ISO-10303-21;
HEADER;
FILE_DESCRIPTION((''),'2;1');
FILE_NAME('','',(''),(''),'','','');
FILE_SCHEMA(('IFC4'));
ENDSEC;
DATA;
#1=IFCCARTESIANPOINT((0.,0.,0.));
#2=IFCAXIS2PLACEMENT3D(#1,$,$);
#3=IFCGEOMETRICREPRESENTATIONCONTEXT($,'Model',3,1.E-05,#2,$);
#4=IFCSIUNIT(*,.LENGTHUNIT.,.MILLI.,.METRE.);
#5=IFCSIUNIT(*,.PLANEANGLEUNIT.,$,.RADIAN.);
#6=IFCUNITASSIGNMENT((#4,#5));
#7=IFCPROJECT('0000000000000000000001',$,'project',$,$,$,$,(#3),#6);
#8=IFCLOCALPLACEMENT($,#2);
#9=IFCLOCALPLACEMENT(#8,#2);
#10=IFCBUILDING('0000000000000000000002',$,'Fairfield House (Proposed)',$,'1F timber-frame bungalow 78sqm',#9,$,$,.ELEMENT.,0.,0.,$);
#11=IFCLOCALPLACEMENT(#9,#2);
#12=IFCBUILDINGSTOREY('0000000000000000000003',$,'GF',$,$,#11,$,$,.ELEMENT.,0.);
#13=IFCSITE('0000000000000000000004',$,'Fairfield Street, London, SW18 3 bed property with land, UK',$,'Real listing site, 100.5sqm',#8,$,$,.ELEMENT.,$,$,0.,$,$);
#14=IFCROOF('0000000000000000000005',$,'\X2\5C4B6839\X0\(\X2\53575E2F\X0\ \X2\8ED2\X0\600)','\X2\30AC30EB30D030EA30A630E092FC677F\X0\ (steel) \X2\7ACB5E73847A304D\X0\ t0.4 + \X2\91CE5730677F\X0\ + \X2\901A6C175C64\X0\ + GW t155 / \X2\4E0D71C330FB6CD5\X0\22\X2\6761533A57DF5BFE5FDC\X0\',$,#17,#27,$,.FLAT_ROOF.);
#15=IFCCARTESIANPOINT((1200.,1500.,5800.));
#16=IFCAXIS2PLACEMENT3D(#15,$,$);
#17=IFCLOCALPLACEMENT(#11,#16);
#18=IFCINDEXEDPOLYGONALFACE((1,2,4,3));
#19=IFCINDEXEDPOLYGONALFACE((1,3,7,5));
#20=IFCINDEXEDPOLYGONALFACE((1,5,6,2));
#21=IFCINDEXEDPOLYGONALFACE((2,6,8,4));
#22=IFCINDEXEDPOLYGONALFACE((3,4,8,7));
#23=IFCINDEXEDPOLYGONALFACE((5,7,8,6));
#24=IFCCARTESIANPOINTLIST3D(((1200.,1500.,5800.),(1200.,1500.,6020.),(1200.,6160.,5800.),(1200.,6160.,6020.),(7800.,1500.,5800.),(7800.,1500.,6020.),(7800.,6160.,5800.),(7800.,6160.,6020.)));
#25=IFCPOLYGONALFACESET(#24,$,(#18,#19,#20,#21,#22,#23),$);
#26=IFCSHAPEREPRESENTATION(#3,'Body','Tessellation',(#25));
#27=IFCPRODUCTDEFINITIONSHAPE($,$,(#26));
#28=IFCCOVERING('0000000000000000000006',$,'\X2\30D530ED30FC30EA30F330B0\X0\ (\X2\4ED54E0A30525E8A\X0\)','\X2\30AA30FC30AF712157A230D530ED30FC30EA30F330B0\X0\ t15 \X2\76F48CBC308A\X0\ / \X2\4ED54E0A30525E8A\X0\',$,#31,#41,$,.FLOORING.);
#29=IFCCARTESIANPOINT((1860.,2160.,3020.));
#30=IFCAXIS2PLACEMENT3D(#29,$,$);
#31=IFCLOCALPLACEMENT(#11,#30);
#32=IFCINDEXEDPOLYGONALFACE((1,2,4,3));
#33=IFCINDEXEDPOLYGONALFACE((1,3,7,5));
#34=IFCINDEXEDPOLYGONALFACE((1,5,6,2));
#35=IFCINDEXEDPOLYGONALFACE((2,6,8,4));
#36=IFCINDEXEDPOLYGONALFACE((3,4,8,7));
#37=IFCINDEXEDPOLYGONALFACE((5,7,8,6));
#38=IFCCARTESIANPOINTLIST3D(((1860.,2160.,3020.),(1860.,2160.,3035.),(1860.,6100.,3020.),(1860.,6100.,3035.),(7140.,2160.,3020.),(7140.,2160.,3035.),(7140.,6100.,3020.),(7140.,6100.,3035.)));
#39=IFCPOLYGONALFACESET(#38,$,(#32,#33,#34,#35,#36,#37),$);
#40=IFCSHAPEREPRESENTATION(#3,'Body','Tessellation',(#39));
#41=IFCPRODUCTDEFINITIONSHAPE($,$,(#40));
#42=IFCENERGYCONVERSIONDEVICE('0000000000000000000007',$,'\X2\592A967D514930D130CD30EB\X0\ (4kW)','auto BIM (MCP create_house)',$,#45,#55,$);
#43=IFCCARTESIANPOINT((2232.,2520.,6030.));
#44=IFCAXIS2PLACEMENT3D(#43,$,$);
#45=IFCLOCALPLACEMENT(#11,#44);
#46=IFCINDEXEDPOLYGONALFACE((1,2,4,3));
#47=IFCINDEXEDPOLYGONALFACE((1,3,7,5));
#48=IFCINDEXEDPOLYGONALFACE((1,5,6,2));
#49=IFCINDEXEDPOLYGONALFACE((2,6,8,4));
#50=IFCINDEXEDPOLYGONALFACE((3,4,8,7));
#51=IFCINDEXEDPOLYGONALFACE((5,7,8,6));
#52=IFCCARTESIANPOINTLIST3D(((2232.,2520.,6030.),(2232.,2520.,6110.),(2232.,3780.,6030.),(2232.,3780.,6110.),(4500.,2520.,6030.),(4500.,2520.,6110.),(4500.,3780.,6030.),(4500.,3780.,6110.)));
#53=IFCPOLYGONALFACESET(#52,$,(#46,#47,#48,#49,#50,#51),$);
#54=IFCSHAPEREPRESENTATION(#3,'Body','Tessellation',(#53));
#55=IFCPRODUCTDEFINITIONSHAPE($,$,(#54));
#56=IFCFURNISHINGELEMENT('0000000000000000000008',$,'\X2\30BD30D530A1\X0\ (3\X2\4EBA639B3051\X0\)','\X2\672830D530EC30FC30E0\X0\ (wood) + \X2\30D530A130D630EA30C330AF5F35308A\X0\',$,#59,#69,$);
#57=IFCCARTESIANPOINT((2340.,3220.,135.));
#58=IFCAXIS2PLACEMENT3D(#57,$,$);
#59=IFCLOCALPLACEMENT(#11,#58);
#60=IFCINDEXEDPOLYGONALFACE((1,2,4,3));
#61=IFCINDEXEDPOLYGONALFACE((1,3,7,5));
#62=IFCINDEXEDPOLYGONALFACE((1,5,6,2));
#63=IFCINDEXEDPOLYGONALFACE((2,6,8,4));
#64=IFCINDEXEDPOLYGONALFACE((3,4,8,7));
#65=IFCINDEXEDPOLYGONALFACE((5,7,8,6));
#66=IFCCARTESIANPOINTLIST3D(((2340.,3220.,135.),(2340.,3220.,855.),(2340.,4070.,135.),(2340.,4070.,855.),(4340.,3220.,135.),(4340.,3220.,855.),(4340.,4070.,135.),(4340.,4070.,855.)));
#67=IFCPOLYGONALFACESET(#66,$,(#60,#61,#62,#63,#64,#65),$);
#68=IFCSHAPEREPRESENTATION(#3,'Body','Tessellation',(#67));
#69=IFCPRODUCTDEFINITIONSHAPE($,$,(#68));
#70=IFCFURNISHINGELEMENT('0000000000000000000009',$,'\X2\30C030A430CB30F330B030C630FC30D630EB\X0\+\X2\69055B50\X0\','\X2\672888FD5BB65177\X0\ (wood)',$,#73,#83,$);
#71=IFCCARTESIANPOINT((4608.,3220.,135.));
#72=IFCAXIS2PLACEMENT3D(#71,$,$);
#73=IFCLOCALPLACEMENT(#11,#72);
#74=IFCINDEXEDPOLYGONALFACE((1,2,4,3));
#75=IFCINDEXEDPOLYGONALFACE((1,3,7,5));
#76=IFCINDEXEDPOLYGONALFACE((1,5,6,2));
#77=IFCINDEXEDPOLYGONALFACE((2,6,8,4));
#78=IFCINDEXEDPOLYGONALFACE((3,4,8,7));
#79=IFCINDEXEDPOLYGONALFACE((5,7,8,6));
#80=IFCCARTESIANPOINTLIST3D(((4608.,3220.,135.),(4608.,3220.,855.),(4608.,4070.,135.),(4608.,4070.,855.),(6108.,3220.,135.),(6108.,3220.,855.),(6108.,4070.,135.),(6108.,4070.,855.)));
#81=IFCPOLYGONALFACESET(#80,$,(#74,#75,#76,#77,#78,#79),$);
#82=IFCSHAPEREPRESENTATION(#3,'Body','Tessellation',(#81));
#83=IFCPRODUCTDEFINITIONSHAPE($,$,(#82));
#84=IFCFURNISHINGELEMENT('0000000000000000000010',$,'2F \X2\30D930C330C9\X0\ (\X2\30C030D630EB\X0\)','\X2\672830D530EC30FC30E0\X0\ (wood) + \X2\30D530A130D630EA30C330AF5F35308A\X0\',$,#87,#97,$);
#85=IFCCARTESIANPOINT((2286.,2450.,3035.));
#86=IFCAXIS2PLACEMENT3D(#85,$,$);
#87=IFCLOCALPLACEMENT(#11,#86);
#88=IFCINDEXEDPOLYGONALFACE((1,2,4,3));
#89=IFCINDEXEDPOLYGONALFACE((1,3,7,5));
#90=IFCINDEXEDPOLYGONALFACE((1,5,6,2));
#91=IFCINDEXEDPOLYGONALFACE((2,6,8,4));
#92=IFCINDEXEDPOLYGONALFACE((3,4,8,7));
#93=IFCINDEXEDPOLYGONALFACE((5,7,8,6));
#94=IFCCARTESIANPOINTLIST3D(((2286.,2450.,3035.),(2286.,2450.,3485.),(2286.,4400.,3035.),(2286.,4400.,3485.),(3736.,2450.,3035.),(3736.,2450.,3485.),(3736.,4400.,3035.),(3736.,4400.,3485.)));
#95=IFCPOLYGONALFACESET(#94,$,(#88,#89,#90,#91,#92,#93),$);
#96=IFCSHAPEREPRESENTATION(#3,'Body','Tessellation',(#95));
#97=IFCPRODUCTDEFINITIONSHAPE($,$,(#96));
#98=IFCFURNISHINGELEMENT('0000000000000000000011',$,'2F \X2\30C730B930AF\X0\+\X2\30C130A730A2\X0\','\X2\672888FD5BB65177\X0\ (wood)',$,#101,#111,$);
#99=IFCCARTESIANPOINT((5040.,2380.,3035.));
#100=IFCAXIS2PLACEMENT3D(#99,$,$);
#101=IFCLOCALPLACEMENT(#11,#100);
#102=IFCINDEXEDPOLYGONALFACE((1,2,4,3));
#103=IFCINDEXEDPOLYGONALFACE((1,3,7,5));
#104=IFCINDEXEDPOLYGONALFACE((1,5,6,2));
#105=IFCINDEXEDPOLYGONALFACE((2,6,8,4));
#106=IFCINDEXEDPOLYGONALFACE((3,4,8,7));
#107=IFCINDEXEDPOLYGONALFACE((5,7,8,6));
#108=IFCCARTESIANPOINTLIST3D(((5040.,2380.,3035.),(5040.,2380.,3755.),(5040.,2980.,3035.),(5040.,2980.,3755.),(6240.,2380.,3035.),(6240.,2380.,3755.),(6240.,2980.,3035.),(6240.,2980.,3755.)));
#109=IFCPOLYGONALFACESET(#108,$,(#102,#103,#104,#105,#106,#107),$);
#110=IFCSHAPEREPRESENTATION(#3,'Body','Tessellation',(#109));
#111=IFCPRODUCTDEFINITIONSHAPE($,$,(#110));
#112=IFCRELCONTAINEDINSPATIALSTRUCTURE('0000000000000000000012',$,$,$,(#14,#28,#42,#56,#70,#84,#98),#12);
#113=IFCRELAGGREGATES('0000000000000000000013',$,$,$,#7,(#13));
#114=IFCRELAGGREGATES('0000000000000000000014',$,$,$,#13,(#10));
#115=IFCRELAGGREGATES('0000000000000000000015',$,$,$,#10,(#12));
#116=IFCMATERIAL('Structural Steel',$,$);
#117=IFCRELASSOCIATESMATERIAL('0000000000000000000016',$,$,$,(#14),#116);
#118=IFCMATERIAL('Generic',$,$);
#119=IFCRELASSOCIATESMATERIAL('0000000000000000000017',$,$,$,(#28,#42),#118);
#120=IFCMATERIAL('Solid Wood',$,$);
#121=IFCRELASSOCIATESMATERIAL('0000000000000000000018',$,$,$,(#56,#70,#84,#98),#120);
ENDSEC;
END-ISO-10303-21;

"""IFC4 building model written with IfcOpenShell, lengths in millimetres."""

from ifc_helpers import new_model, si_unit, frame, frame_2d, origin, place, context, project, spatial, rectangle, extrude, material, element, save


model = new_model("IFC4")

# Units and contexts
model_context = context("Model", 3, precision=1e-05, world=origin())
ifc_project = project(units=[si_unit("LENGTHUNIT", "METRE", prefix="MILLI"), si_unit("PLANEANGLEUNIT", "RADIAN")], contexts=[model_context])

# Site, building, storey
site_placement = place(None, origin())
site = spatial("IfcSite", under=ifc_project, at=site_placement, Name="Fairfield Street, London, SW18 3 bed property with land, UK", ObjectType="Real listing site, 100.5sqm", CompositionType="ELEMENT", RefElevation=0.0)
building_placement = place(site_placement, origin())
building = spatial("IfcBuilding", under=site, at=building_placement, Name="Fairfield House (Proposed)", ObjectType="1F timber-frame bungalow 78sqm", CompositionType="ELEMENT", ElevationOfRefHeight=0.0, ElevationOfTerrain=0.0)
storey_placement = place(building_placement, origin())
storey = spatial("IfcBuildingStorey", under=building, at=storey_placement, Name="GF", CompositionType="ELEMENT", Elevation=0.0)

# Shared definitions
ifc_material_1 = material(Name="Solid Wood")

# Shared definitions
ifc_material_2 = material(Name="Generic")

# Roof
ifc_material_3 = material(Name="Structural Steel")
for number, where, name in (
    (1, (1200.0, 1500.0, 5800.0), "屋根(南帯 軒600)"),
):
    element("IfcRoof", number, at=place(storey_placement, frame(where)), inside=storey, material=ifc_material_3, Name=name, Description="ガルバリウム鋼板 (steel) 立平葺き t0.4 + 野地板 + 通気層 + GW t155 / 不燃・法22条区域対応", PredefinedType="FLAT_ROOF", context=model_context, shape_type="SweptSolid", body=[
        extrude(rectangle(XDim=6600.0, YDim=4660.0, at=frame_2d((3300.0, 2330.0))), frame((1200.0, 1500.0, 5800.0)), (0.0, 0.0, 1.0), 220.0),
    ])

# Covering
covering_placement = place(storey_placement, frame((1860.0, 2160.0, 3020.0)))
element("IfcCovering", 2, at=covering_placement, inside=storey, material=ifc_material_2, Name="フローリング (仕上げ床)", Description="オーク無垢フローリング t15 直貼り / 仕上げ床", PredefinedType="FLOORING", context=model_context, shape_type="SweptSolid", body=[
    extrude(rectangle(XDim=5280.0, YDim=3940.0, at=frame_2d((2640.0, 1970.0))), frame((1860.0, 2160.0, 3020.0)), (0.0, 0.0, 1.0), 15.0),
])

# Energy conversion device
energy_conversion_device_placement = place(storey_placement, frame((2232.0, 2520.0, 6030.0)))
element("IfcEnergyConversionDevice", 3, at=energy_conversion_device_placement, inside=storey, material=ifc_material_2, Name="太陽光パネル (4kW)", Description="auto BIM (MCP create_house)", context=model_context, shape_type="SweptSolid", body=[
    extrude(rectangle(XDim=2268.0, YDim=1260.0, at=frame_2d((1134.0, 630.0))), frame((2232.0, 2520.0, 6030.0)), (0.0, 0.0, 1.0), 80.0),
])

# Furnishing elements
furnishing_1_placement = place(storey_placement, frame((2340.0, 3220.0, 135.0)))
element("IfcFurnishingElement", 4, at=furnishing_1_placement, inside=storey, material=ifc_material_1, Name="ソファ (3人掛け)", Description="木フレーム (wood) + ファブリック張り", context=model_context, shape_type="SweptSolid", body=[
    extrude(rectangle(XDim=2000.0, YDim=850.0, at=frame_2d((1000.0, 425.0))), frame((2340.0, 3220.0, 135.0)), (0.0, 0.0, 1.0), 720.0),
])
furnishing_2_placement = place(storey_placement, frame((4608.0, 3220.0, 135.0)))
element("IfcFurnishingElement", 5, at=furnishing_2_placement, inside=storey, material=ifc_material_1, Name="ダイニングテーブル+椅子", Description="木製家具 (wood)", context=model_context, shape_type="SweptSolid", body=[
    extrude(rectangle(XDim=1500.0, YDim=850.0, at=frame_2d((750.0, 425.0))), frame((4608.0, 3220.0, 135.0)), (0.0, 0.0, 1.0), 720.0),
])
furnishing_3_placement = place(storey_placement, frame((2286.0, 2450.0, 3035.0)))
element("IfcFurnishingElement", 6, at=furnishing_3_placement, inside=storey, material=ifc_material_1, Name="2F ベッド (ダブル)", Description="木フレーム (wood) + ファブリック張り", context=model_context, shape_type="SweptSolid", body=[
    extrude(rectangle(XDim=1450.0, YDim=1950.0, at=frame_2d((725.0, 975.0))), frame((2286.0, 2450.0, 3035.0)), (0.0, 0.0, 1.0), 450.0),
])
furnishing_4_placement = place(storey_placement, frame((5040.0, 2380.0, 3035.0)))
element("IfcFurnishingElement", 7, at=furnishing_4_placement, inside=storey, material=ifc_material_1, Name="2F デスク+チェア", Description="木製家具 (wood)", context=model_context, shape_type="SweptSolid", body=[
    extrude(rectangle(XDim=1200.0, YDim=600.0, at=frame_2d((600.0, 300.0))), frame((5040.0, 2380.0, 3035.0)), (0.0, 0.0, 1.0), 720.0),
])

save(model, "model.ifc")
